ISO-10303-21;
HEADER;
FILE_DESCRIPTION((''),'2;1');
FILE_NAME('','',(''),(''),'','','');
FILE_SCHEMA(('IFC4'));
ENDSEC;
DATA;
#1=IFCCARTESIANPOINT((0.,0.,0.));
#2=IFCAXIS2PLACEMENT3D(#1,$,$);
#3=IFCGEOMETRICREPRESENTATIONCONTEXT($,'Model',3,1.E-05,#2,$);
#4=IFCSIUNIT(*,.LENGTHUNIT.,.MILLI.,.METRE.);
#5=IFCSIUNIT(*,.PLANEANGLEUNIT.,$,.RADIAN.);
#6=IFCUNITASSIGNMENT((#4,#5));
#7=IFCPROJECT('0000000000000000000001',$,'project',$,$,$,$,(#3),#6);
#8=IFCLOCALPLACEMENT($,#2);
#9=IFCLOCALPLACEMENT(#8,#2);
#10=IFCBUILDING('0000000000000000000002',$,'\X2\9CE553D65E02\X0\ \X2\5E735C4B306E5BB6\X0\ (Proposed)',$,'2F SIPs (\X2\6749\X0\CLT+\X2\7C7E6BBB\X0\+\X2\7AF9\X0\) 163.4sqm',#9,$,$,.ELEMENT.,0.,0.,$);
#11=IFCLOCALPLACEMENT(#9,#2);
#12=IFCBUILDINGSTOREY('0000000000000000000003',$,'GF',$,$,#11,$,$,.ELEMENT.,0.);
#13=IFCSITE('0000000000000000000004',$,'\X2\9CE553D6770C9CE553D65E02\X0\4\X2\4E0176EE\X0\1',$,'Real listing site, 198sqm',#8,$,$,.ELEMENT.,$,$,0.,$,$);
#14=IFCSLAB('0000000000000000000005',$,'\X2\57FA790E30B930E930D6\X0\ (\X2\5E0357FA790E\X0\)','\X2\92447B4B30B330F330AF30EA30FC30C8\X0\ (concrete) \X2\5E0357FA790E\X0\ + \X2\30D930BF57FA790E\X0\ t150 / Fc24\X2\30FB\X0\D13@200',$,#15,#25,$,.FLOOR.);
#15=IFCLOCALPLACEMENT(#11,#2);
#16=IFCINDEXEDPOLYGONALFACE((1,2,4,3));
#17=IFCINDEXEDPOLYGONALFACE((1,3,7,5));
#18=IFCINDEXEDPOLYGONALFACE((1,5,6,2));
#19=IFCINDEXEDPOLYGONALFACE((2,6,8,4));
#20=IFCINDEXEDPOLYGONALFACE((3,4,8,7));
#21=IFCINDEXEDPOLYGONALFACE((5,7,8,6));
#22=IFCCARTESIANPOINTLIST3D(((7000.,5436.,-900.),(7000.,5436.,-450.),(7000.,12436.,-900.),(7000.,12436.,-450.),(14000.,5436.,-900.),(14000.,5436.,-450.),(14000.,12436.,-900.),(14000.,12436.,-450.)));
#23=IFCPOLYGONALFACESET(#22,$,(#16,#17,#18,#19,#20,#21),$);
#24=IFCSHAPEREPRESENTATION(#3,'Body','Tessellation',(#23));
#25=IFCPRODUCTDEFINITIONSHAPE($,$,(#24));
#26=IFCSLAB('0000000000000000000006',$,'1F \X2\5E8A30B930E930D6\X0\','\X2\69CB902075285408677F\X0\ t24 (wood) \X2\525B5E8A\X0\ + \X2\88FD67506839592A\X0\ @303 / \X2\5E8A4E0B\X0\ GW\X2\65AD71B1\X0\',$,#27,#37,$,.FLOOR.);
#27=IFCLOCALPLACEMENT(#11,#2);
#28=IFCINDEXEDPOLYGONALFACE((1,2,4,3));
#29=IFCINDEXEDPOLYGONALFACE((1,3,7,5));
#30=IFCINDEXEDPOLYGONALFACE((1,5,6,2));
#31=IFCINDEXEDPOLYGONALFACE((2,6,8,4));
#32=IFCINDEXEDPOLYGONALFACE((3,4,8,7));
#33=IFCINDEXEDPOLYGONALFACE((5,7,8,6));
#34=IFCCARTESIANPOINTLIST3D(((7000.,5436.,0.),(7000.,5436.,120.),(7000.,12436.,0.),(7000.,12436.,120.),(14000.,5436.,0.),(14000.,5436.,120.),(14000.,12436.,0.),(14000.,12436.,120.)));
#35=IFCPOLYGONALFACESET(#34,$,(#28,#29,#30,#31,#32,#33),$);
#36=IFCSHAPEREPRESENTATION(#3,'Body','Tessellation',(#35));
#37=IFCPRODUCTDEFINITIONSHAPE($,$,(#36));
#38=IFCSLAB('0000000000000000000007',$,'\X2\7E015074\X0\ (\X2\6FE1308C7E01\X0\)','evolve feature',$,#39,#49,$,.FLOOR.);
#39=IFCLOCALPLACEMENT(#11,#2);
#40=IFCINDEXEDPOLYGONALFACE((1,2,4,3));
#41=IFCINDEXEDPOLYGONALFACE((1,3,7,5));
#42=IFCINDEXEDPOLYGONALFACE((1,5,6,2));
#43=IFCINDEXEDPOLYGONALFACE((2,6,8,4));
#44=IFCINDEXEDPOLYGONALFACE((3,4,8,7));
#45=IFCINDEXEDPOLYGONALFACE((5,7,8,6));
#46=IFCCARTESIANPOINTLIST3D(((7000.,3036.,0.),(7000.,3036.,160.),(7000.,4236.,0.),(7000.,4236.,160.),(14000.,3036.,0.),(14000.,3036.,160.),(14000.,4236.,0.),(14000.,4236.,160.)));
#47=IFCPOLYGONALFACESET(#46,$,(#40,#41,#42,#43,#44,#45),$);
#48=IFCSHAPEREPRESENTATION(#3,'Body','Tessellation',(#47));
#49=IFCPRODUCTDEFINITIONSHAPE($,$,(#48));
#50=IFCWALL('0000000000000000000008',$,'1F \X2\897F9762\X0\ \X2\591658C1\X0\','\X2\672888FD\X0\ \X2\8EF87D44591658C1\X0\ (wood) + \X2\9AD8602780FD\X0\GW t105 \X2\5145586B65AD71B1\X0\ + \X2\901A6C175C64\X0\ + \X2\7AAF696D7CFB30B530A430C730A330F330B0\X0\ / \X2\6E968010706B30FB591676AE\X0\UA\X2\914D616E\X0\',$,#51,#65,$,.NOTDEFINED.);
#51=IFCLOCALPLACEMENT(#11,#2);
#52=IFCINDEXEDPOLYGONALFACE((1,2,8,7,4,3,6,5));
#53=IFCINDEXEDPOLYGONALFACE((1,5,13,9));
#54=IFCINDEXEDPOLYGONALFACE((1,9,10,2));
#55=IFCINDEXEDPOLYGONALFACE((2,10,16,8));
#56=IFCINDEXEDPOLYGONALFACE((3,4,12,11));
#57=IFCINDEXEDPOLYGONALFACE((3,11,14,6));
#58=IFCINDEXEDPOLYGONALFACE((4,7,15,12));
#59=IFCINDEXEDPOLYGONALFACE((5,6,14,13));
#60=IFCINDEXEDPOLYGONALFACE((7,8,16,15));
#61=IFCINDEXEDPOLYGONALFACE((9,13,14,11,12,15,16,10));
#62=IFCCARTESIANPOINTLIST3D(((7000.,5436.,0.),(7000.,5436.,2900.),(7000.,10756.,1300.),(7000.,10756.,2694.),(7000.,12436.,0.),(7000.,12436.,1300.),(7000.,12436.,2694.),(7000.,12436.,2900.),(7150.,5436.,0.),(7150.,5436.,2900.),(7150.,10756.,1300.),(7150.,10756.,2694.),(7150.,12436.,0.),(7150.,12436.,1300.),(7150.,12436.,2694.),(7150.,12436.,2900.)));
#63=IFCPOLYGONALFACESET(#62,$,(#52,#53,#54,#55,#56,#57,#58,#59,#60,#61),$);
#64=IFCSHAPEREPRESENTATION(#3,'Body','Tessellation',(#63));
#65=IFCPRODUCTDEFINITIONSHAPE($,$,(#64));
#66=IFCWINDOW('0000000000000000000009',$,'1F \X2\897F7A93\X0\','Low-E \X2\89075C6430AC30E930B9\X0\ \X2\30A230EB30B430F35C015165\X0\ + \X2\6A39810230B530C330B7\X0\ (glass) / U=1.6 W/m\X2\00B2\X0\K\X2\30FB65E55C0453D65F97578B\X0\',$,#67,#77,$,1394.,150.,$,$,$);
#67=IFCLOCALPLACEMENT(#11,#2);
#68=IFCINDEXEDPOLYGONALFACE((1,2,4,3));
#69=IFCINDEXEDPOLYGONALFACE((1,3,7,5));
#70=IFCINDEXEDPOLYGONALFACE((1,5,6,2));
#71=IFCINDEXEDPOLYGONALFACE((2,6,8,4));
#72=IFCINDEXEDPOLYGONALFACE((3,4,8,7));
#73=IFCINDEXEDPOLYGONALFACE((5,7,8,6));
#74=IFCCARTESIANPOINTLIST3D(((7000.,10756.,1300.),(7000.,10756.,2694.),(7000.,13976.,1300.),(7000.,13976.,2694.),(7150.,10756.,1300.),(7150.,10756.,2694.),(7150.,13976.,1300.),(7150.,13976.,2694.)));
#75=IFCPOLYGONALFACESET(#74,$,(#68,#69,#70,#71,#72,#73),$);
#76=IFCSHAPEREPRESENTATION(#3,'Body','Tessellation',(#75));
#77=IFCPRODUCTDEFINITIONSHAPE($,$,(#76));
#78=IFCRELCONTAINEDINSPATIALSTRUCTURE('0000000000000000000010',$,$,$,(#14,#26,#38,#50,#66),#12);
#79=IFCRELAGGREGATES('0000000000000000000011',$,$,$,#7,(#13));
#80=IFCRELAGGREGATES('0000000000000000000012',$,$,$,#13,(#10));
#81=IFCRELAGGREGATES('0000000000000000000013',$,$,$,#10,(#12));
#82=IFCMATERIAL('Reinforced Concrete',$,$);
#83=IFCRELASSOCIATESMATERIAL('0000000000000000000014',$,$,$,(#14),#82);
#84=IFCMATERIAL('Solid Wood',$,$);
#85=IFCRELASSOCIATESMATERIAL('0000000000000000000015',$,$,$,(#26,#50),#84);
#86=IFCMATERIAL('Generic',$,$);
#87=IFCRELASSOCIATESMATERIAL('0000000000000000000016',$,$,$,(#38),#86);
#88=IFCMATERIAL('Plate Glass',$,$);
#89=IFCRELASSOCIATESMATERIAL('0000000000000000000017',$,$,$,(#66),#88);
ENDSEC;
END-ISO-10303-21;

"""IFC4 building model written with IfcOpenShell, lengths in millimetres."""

from ifc_helpers import new_model, si_unit, frame, frame_2d, origin, place, context, project, spatial, rectangle, extrude, material, element, fill, save


model = new_model("IFC4")

# Units and contexts
model_context = context("Model", 3, precision=1e-05, world=origin())
ifc_project = project(units=[si_unit("LENGTHUNIT", "METRE", prefix="MILLI"), si_unit("PLANEANGLEUNIT", "RADIAN")], contexts=[model_context])

# Site, building, storey
site_placement = place(None, origin())
site = spatial("IfcSite", under=ifc_project, at=site_placement, Name="鳥取県鳥取市4丁目1", ObjectType="Real listing site, 198sqm", CompositionType="ELEMENT", RefElevation=0.0)
building_placement = place(site_placement, origin())
building = spatial("IfcBuilding", under=site, at=building_placement, Name="鳥取市 平屋の家 (Proposed)", ObjectType="2F SIPs (杉CLT+籾殻+竹) 163.4sqm", CompositionType="ELEMENT", ElevationOfRefHeight=0.0, ElevationOfTerrain=0.0)
storey_placement = place(building_placement, origin())
storey = spatial("IfcBuildingStorey", under=building, at=storey_placement, Name="GF", CompositionType="ELEMENT", Elevation=0.0)

# Slabs
ifc_material_1 = material(Name="Reinforced Concrete")
slab_1_placement = place(storey_placement, frame((3500.0, 2718.0, -450.0)))
element("IfcSlab", 1, at=slab_1_placement, inside=storey, material=ifc_material_1, Name="基礎スラブ (布基礎)", Description="鉄筋コンクリート (concrete) 布基礎 + ベタ基礎 t150 / Fc24・D13@200", PredefinedType="FLOOR", context=model_context, shape_type="SweptSolid", body=[
    extrude(rectangle(XDim=7000.0, YDim=7000.0, at=frame_2d((3500.0, 3500.0))), frame((3500.0, 2718.0, -450.0)), (0.0, 0.0, 1.0), 450.0),
])
ifc_material_2 = material(Name="Solid Wood")
slab_2_placement = place(storey_placement, frame((3500.0, 2718.0, 0.0)))
element("IfcSlab", 2, at=slab_2_placement, inside=storey, material=ifc_material_2, Name="1F 床スラブ", Description="構造用合板 t24 (wood) 剛床 + 製材根太 @303 / 床下 GW断熱", PredefinedType="FLOOR", context=model_context, shape_type="SweptSolid", body=[
    extrude(rectangle(XDim=7000.0, YDim=7000.0, at=frame_2d((3500.0, 3500.0))), frame((3500.0, 2718.0, 0.0)), (0.0, 0.0, 1.0), 120.0),
])
ifc_material_3 = material(Name="Generic")
slab_3_placement = place(storey_placement, frame((3500.0, 1518.0, 0.0)))
element("IfcSlab", 3, at=slab_3_placement, inside=storey, material=ifc_material_3, Name="縁側 (濡れ縁)", Description="evolve feature", PredefinedType="FLOOR", context=model_context, shape_type="SweptSolid", body=[
    extrude(rectangle(XDim=7000.0, YDim=1200.0, at=frame_2d((3500.0, 600.0))), frame((3500.0, 1518.0, 0.0)), (0.0, 0.0, 1.0), 160.0),
])

# Shared definitions
ifc_material_4 = material(Name="Plate Glass")

# Wall, opening, window
wall_1_placement = place(storey_placement, frame((3500.0, 2718.0, 0.0)))
wall_1 = element("IfcWall", 4, at=wall_1_placement, inside=storey, material=ifc_material_2, Name="1F 西面 外壁", Description="木製 軸組外壁 (wood) + 高性能GW t105 充填断熱 + 通気層 + 窯業系サイディング / 準耐火・外皮UA配慮", PredefinedType="NOTDEFINED", context=model_context, shape_type="SweptSolid", body=[
    extrude(rectangle(XDim=150.0, YDim=7000.0, at=frame_2d((75.0, 3500.0))), frame((3500.0, 2718.0, 0.0)), (0.0, 0.0, 1.0), 2900.0),
])
opening_1_placement = place(storey_placement, frame((3500.0, 5378.0, 650.0)))
opening_1 = element("IfcOpeningElement", 5, at=opening_1_placement, cuts=wall_1, PredefinedType="NOTDEFINED", context=model_context, shape_type="SweptSolid", body=[
    extrude(rectangle(XDim=150.0, YDim=3220.0, at=frame_2d((75.0, 1610.0))), frame((3500.0, 5378.0, 650.0)), (0.0, 0.0, 1.0), 1394.0),
])
window_1_placement = place(storey_placement, frame((3500.0, 5378.0, 650.0)))
window_1 = element("IfcWindow", 6, at=window_1_placement, inside=storey, material=ifc_material_4, Name="1F 西窓", Description="Low-E 複層ガラス アルゴン封入 + 樹脂サッシ (glass) / U=1.6 W/m²K・日射取得型", OverallHeight=1394.0, OverallWidth=150.0, context=model_context, shape_type="SweptSolid", body=[
    extrude(rectangle(XDim=150.0, YDim=3220.0, at=frame_2d((75.0, 1610.0))), frame((3500.0, 5378.0, 650.0)), (0.0, 0.0, 1.0), 1394.0),
])
fill(opening_1, window_1)

save(model, "model.ifc")
